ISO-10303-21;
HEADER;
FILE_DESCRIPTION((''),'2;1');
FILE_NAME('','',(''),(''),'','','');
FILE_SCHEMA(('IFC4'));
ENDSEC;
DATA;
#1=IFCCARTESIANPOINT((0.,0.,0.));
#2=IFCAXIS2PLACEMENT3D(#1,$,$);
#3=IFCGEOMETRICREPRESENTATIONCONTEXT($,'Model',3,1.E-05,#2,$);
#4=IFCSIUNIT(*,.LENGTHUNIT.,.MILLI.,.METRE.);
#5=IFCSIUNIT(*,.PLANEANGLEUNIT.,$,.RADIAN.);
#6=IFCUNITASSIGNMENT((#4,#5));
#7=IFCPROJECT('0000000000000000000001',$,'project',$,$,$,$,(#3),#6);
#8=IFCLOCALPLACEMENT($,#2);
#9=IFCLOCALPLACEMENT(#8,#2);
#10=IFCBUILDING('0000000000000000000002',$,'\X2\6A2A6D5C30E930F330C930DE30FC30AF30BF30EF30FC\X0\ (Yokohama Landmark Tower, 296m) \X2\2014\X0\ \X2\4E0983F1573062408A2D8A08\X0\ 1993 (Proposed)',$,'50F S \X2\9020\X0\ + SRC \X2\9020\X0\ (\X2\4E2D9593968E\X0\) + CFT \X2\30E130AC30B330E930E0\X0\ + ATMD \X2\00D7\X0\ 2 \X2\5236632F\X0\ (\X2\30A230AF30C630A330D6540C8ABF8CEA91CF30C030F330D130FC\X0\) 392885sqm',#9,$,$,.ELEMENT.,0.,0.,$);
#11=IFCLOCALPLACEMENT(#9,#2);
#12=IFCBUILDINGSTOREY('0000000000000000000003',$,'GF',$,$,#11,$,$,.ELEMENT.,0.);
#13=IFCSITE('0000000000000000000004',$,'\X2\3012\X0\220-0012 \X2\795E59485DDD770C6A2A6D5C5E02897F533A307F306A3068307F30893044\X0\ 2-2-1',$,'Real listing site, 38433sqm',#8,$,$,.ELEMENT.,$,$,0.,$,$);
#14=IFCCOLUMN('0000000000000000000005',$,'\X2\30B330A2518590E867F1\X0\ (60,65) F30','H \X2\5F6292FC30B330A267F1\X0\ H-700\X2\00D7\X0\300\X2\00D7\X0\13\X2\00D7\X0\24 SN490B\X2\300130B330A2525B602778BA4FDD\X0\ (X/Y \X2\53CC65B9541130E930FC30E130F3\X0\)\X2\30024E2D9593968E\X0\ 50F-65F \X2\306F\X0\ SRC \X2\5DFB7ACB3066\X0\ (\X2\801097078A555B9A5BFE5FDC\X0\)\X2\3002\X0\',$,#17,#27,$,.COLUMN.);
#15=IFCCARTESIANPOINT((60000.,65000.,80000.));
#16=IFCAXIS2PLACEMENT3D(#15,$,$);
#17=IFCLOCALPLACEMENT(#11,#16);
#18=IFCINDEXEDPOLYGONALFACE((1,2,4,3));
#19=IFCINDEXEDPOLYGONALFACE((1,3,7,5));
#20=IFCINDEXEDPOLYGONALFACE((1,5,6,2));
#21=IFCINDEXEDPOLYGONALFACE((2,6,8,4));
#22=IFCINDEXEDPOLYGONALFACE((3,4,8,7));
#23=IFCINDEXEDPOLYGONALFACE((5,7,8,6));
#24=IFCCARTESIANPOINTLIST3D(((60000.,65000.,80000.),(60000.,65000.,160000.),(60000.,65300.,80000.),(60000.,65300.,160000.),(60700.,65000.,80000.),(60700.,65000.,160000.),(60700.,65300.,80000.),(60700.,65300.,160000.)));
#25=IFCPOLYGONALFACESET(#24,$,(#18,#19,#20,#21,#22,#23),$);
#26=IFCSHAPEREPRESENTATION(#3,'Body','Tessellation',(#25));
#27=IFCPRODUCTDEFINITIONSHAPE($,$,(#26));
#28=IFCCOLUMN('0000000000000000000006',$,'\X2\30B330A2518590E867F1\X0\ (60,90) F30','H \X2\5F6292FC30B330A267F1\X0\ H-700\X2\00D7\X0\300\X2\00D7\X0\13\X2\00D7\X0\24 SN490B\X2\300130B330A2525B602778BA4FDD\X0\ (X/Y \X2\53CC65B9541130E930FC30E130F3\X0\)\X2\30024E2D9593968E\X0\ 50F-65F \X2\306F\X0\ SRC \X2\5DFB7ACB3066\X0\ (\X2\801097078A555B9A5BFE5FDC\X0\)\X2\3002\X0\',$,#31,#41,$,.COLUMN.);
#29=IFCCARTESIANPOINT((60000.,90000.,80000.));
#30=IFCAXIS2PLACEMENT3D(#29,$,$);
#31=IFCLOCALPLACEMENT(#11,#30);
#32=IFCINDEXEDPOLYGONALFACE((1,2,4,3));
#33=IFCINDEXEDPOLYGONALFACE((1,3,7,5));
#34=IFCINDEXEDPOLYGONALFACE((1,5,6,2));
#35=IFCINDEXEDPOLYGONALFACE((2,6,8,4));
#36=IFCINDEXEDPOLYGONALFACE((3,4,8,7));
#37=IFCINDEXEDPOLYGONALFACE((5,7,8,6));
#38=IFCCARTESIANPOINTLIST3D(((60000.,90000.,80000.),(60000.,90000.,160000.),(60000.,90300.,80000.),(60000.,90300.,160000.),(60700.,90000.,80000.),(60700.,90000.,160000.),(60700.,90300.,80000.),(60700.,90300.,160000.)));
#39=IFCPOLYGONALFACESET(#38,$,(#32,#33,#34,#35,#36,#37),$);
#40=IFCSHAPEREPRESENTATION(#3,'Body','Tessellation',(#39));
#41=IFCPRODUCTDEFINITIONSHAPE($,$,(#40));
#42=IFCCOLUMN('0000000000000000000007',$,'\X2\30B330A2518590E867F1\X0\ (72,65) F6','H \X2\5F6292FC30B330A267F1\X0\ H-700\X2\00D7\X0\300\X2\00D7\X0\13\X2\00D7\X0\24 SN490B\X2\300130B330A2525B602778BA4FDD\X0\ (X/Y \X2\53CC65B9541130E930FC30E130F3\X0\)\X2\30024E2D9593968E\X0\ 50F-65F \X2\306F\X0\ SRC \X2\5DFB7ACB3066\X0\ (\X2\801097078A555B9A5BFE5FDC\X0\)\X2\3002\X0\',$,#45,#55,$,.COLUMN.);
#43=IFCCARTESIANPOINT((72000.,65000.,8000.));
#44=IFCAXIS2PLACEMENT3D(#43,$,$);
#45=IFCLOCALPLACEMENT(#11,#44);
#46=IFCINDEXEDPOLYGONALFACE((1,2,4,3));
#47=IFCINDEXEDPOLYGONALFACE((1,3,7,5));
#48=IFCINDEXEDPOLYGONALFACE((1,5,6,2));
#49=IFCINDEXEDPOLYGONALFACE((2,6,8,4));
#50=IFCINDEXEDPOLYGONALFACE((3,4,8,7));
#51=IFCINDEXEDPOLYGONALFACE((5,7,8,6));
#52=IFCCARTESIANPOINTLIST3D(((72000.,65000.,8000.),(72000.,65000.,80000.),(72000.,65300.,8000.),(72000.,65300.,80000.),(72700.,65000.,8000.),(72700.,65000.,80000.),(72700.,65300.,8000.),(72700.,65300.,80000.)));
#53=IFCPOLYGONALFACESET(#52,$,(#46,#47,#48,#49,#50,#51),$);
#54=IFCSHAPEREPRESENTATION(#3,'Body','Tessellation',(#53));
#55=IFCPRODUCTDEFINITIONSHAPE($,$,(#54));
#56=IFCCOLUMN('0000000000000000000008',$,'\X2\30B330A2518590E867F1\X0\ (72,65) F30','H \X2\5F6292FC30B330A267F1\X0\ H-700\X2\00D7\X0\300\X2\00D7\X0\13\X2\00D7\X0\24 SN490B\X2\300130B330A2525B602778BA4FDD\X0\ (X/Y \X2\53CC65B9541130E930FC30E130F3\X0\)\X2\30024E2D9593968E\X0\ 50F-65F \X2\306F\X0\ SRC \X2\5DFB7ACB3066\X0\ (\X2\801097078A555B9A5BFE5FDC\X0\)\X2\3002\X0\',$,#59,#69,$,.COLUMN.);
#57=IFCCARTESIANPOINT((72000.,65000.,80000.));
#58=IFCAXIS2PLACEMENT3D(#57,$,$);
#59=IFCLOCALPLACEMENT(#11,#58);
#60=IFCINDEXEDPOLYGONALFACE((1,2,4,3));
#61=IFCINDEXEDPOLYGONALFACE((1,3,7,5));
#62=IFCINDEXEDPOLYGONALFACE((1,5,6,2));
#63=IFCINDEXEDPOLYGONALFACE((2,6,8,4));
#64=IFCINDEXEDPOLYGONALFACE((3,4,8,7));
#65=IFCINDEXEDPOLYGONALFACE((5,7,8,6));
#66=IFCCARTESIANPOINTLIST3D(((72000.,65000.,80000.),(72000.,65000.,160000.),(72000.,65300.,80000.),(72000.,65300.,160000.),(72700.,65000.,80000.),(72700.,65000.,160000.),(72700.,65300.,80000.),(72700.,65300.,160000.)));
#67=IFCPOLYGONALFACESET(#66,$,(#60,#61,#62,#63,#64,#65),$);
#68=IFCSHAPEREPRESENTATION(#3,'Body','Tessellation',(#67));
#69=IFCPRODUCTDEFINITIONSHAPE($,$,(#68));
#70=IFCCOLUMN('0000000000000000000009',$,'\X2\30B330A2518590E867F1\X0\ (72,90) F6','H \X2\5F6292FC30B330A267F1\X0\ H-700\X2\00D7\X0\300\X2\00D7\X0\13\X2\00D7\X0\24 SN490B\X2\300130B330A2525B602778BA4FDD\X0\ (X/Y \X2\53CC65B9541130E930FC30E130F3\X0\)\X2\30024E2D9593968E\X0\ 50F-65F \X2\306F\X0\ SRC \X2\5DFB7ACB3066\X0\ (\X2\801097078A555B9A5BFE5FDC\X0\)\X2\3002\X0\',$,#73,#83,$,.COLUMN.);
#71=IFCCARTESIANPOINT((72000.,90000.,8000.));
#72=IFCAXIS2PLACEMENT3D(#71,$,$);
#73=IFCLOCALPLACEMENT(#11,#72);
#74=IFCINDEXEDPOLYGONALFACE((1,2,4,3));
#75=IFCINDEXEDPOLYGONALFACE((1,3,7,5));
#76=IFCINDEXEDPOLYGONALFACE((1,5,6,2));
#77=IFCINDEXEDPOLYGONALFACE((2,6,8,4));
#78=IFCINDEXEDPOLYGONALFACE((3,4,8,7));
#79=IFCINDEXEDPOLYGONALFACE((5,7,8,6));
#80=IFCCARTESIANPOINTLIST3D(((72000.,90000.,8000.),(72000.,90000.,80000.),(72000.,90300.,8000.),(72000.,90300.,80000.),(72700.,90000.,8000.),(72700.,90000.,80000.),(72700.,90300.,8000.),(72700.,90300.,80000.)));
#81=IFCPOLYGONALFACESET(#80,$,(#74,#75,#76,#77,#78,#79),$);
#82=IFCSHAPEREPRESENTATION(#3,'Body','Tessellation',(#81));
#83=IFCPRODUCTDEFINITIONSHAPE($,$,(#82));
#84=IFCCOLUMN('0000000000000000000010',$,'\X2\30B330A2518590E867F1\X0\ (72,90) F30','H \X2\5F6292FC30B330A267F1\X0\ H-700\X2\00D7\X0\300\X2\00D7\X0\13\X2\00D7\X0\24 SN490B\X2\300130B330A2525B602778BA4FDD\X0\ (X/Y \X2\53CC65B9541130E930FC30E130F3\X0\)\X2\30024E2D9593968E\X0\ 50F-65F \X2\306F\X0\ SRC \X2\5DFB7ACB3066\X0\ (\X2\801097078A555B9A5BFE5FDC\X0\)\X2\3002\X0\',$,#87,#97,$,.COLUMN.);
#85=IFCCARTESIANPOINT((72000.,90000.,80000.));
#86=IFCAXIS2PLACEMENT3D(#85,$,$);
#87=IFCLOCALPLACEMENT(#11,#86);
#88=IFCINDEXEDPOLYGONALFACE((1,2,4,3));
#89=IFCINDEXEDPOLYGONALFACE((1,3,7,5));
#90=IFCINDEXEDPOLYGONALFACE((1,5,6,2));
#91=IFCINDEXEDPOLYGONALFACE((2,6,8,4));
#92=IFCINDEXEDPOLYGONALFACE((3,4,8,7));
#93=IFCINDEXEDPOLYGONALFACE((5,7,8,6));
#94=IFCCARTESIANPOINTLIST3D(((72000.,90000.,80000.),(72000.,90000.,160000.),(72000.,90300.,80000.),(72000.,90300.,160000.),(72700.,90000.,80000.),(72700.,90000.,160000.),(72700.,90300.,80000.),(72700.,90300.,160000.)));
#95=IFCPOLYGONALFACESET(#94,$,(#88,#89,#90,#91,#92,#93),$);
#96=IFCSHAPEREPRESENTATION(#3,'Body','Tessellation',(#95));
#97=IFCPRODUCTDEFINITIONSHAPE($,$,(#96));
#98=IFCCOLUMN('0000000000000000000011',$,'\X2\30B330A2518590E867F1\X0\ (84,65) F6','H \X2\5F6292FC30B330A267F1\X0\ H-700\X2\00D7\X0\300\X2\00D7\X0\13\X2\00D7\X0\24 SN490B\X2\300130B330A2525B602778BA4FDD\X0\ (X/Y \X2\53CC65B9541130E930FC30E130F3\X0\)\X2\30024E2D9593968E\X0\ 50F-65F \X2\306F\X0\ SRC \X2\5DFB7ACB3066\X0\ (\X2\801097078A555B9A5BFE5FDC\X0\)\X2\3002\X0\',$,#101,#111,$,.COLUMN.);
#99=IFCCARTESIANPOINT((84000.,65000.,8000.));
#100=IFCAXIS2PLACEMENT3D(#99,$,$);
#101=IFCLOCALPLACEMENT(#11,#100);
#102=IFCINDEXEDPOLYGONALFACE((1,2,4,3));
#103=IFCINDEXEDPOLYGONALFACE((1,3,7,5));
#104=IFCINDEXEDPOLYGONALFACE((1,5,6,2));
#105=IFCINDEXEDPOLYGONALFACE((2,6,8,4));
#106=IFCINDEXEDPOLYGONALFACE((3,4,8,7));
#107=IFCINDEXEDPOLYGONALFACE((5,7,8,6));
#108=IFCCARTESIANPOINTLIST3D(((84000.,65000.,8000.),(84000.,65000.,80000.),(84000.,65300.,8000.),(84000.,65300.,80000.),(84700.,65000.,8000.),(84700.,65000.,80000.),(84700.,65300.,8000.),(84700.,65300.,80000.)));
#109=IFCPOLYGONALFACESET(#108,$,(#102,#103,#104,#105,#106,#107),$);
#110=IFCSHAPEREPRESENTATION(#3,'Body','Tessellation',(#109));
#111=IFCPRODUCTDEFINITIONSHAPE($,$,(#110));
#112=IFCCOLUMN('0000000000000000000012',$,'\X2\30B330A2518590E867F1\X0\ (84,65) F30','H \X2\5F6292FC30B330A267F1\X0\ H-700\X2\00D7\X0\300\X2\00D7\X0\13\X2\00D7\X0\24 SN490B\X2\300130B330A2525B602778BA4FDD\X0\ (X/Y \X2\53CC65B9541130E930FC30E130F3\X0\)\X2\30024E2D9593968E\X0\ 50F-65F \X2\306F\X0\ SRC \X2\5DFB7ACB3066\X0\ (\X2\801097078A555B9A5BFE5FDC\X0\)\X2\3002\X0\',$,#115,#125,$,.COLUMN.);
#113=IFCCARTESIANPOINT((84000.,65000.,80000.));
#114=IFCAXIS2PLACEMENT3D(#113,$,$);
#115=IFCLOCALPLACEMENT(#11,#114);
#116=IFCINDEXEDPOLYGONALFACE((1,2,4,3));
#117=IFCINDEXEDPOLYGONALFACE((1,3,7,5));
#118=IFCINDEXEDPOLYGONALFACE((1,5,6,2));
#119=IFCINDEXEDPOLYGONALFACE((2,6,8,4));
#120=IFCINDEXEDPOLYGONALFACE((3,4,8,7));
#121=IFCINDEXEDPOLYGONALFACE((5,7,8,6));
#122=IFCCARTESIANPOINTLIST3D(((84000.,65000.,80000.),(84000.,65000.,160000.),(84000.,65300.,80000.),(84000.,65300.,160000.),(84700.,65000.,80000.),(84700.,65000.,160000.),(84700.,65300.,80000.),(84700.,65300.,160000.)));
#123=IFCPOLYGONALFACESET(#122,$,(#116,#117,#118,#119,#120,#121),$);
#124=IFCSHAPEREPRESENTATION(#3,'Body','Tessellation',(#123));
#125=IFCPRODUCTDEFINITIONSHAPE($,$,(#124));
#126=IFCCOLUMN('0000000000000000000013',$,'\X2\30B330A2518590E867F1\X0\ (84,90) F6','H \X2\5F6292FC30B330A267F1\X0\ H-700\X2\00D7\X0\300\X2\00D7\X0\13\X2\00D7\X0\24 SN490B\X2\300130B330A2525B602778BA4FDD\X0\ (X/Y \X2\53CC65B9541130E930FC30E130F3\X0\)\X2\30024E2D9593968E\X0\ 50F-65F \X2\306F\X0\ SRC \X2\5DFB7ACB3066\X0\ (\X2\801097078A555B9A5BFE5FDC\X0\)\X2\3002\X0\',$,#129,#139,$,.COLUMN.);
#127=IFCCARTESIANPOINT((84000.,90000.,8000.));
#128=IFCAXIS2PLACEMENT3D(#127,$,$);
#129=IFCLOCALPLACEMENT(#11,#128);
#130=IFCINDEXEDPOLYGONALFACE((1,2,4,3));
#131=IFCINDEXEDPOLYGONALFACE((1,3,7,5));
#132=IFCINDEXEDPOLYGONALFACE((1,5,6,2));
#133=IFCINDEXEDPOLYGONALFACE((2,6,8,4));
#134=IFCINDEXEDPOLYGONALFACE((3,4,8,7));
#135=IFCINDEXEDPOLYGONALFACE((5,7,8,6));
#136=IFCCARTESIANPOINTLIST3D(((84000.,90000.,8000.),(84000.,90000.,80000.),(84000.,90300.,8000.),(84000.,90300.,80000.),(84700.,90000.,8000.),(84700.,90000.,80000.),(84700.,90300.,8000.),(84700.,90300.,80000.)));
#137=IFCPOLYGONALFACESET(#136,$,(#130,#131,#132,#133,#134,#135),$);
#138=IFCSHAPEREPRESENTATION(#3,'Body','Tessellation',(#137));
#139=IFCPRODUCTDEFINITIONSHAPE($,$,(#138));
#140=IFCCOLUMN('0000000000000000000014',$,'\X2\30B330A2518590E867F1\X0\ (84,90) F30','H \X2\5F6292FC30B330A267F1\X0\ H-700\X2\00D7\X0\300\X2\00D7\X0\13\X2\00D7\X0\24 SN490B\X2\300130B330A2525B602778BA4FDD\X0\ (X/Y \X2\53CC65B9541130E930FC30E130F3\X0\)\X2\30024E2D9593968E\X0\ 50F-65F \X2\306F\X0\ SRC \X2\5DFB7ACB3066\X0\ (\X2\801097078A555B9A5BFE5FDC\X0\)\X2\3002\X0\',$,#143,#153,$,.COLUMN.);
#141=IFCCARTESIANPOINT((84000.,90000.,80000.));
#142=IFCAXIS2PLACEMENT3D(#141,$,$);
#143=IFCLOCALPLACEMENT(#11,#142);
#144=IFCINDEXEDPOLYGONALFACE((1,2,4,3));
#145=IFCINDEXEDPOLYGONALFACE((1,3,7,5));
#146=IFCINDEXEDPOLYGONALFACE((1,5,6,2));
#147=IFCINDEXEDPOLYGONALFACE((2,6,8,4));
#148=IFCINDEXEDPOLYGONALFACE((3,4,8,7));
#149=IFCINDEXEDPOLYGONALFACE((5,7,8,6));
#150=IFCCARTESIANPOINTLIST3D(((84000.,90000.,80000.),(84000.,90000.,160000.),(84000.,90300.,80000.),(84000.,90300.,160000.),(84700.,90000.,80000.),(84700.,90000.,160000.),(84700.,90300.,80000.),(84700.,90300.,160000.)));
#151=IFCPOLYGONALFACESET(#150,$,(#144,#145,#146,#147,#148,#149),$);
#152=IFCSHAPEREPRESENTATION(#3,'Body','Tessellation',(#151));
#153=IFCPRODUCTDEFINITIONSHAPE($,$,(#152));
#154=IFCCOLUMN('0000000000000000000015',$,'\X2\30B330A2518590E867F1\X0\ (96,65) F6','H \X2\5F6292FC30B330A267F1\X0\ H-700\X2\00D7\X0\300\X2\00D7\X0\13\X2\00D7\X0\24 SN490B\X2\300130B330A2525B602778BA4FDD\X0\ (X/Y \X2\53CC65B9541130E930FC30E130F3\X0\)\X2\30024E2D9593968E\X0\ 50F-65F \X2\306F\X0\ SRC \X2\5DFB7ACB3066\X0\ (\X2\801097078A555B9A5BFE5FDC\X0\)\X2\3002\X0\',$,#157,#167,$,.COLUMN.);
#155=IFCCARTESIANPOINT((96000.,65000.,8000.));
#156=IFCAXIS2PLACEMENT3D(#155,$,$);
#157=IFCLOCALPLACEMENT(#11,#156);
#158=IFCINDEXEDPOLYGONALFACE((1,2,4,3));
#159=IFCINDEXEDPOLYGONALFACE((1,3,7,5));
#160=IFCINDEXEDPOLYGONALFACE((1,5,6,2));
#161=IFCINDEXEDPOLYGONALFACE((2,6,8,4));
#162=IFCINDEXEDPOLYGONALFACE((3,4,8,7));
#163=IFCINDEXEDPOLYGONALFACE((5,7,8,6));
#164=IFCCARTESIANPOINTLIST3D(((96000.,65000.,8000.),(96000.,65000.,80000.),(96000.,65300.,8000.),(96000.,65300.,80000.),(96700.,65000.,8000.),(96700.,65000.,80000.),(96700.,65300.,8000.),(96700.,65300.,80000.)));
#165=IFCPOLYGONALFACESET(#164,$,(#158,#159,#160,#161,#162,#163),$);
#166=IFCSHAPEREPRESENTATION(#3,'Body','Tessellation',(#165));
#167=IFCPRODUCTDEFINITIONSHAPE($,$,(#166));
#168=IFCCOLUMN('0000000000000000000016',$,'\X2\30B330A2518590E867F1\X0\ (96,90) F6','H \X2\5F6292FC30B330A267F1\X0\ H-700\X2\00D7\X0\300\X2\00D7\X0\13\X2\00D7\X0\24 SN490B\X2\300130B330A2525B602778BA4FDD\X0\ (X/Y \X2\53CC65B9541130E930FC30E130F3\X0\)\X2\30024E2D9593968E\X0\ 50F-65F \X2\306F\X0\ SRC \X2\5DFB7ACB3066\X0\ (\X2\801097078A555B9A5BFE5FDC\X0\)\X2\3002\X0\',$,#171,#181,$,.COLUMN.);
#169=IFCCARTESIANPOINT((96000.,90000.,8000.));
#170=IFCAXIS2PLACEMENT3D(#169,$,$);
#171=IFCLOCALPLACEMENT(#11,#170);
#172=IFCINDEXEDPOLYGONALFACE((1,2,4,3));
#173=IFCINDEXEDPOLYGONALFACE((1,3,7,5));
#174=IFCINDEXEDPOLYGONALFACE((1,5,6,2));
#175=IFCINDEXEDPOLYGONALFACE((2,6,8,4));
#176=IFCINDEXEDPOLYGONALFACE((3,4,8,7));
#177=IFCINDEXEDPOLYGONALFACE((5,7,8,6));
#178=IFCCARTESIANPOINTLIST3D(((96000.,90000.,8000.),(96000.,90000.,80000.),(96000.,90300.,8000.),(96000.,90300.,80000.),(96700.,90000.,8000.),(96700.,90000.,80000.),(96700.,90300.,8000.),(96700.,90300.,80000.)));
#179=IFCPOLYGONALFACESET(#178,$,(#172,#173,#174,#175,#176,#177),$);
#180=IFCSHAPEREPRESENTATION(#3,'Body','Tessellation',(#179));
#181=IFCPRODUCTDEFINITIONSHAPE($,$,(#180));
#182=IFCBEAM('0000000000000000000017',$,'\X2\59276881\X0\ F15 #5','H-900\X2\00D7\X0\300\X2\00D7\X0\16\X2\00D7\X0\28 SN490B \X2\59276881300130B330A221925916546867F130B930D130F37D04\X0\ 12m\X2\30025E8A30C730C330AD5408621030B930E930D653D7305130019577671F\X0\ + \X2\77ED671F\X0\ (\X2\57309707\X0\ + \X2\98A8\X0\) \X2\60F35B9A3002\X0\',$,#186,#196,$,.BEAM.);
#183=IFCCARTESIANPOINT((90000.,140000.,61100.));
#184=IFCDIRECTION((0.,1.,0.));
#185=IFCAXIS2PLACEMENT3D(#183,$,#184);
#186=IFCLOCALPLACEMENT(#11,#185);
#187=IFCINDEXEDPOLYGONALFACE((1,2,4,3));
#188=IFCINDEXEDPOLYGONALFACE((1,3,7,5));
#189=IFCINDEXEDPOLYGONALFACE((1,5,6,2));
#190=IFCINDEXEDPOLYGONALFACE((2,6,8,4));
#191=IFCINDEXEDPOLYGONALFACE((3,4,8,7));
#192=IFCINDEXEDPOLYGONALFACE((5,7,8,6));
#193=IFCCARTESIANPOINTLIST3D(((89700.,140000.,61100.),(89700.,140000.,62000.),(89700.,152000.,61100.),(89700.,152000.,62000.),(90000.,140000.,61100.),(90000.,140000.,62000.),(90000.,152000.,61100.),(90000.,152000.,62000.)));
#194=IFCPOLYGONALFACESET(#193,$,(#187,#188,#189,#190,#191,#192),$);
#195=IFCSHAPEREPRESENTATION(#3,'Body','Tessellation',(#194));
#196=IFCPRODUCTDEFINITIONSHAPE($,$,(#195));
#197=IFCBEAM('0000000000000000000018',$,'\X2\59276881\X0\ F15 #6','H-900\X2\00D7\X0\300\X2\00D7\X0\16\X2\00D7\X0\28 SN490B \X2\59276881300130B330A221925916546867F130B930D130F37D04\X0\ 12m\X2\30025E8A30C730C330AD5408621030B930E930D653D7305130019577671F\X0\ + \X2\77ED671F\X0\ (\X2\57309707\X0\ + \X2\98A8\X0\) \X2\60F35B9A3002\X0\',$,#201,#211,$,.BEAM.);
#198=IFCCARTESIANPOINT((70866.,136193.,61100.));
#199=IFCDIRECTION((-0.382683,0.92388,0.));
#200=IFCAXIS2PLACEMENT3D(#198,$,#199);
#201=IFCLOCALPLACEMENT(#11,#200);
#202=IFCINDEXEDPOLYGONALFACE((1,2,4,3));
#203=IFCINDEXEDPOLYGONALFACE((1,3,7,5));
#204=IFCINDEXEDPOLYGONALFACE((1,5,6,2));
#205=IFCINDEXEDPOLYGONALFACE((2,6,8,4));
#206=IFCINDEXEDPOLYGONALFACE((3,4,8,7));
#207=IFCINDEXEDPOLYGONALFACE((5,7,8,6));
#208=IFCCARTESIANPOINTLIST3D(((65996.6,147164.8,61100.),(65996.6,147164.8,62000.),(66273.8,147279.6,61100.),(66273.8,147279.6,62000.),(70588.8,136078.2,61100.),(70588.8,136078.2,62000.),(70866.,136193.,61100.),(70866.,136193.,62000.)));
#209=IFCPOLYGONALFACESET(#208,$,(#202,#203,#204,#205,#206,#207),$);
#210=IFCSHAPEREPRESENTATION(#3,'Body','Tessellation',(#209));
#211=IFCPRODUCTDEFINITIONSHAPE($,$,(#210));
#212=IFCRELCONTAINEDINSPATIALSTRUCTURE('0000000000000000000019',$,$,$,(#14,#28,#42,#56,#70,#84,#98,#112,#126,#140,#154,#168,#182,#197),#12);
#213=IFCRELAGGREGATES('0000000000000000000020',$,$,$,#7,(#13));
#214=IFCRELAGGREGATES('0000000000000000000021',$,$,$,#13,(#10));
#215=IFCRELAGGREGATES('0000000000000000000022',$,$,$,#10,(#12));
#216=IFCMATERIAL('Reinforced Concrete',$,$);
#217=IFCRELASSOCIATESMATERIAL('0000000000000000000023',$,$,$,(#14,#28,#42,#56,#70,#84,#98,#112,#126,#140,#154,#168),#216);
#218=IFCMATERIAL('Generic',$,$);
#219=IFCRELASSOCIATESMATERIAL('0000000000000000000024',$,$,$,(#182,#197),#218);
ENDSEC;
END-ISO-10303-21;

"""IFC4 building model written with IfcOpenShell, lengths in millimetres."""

from ifc_helpers import new_model, si_unit, frame, frame_2d, origin, place, context, project, spatial, rectangle, extrude, material, element, save


model = new_model("IFC4")

# Units and contexts
model_context = context("Model", 3, precision=1e-05, world=origin())
ifc_project = project(units=[si_unit("LENGTHUNIT", "METRE", prefix="MILLI"), si_unit("PLANEANGLEUNIT", "RADIAN")], contexts=[model_context])

# Site, building, storey
site_placement = place(None, origin())
site = spatial("IfcSite", under=ifc_project, at=site_placement, Name="〒220-0012 神奈川県横浜市西区みなとみらい 2-2-1", ObjectType="Real listing site, 38433sqm", CompositionType="ELEMENT", RefElevation=0.0)
building_placement = place(site_placement, origin())
building = spatial("IfcBuilding", under=site, at=building_placement, Name="横浜ランドマークタワー (Yokohama Landmark Tower, 296m) — 三菱地所設計 1993 (Proposed)", ObjectType="50F S 造 + SRC 造 (中間階) + CFT メガコラム + ATMD × 2 制振 (アクティブ同調質量ダンパー) 392885sqm", CompositionType="ELEMENT", ElevationOfRefHeight=0.0, ElevationOfTerrain=0.0)
storey_placement = place(building_placement, origin())
storey = spatial("IfcBuildingStorey", under=building, at=storey_placement, Name="GF", CompositionType="ELEMENT", Elevation=0.0)

# Columns
ifc_material_1 = material(Name="Reinforced Concrete")
column_1_placement = place(storey_placement, frame((60000.0, 65000.0, 80000.0)))
element("IfcColumn", 1, at=column_1_placement, inside=storey, material=ifc_material_1, Name="コア内部柱 (60,65) F30", Description="H 形鋼コア柱 H-700×300×13×24 SN490B、コア剛性確保 (X/Y 双方向ラーメン)。中間階 50F-65F は SRC 巻立て (耐震評定対応)。", PredefinedType="COLUMN", context=model_context, shape_type="SweptSolid", body=[
    extrude(rectangle(XDim=700.0, YDim=300.0, at=frame_2d((350.0, 150.0))), frame((60000.0, 65000.0, 80000.0)), (0.0, 0.0, 1.0), 80000.0),
])
column_2_placement = place(storey_placement, frame((60000.0, 90000.0, 80000.0)))
element("IfcColumn", 2, at=column_2_placement, inside=storey, material=ifc_material_1, Name="コア内部柱 (60,90) F30", Description="H 形鋼コア柱 H-700×300×13×24 SN490B、コア剛性確保 (X/Y 双方向ラーメン)。中間階 50F-65F は SRC 巻立て (耐震評定対応)。", PredefinedType="COLUMN", context=model_context, shape_type="SweptSolid", body=[
    extrude(rectangle(XDim=700.0, YDim=300.0, at=frame_2d((350.0, 150.0))), frame((60000.0, 90000.0, 80000.0)), (0.0, 0.0, 1.0), 80000.0),
])
column_3_placement = place(storey_placement, frame((72000.0, 65000.0, 8000.0)))
element("IfcColumn", 3, at=column_3_placement, inside=storey, material=ifc_material_1, Name="コア内部柱 (72,65) F6", Description="H 形鋼コア柱 H-700×300×13×24 SN490B、コア剛性確保 (X/Y 双方向ラーメン)。中間階 50F-65F は SRC 巻立て (耐震評定対応)。", PredefinedType="COLUMN", context=model_context, shape_type="SweptSolid", body=[
    extrude(rectangle(XDim=700.0, YDim=300.0, at=frame_2d((350.0, 150.0))), frame((72000.0, 65000.0, 8000.0)), (0.0, 0.0, 1.0), 72000.0),
])
column_4_placement = place(storey_placement, frame((72000.0, 65000.0, 80000.0)))
element("IfcColumn", 4, at=column_4_placement, inside=storey, material=ifc_material_1, Name="コア内部柱 (72,65) F30", Description="H 形鋼コア柱 H-700×300×13×24 SN490B、コア剛性確保 (X/Y 双方向ラーメン)。中間階 50F-65F は SRC 巻立て (耐震評定対応)。", PredefinedType="COLUMN", context=model_context, shape_type="SweptSolid", body=[
    extrude(rectangle(XDim=700.0, YDim=300.0, at=frame_2d((350.0, 150.0))), frame((72000.0, 65000.0, 80000.0)), (0.0, 0.0, 1.0), 80000.0),
])
column_5_placement = place(storey_placement, frame((72000.0, 90000.0, 8000.0)))
element("IfcColumn", 5, at=column_5_placement, inside=storey, material=ifc_material_1, Name="コア内部柱 (72,90) F6", Description="H 形鋼コア柱 H-700×300×13×24 SN490B、コア剛性確保 (X/Y 双方向ラーメン)。中間階 50F-65F は SRC 巻立て (耐震評定対応)。", PredefinedType="COLUMN", context=model_context, shape_type="SweptSolid", body=[
    extrude(rectangle(XDim=700.0, YDim=300.0, at=frame_2d((350.0, 150.0))), frame((72000.0, 90000.0, 8000.0)), (0.0, 0.0, 1.0), 72000.0),
])
column_6_placement = place(storey_placement, frame((72000.0, 90000.0, 80000.0)))
element("IfcColumn", 6, at=column_6_placement, inside=storey, material=ifc_material_1, Name="コア内部柱 (72,90) F30", Description="H 形鋼コア柱 H-700×300×13×24 SN490B、コア剛性確保 (X/Y 双方向ラーメン)。中間階 50F-65F は SRC 巻立て (耐震評定対応)。", PredefinedType="COLUMN", context=model_context, shape_type="SweptSolid", body=[
    extrude(rectangle(XDim=700.0, YDim=300.0, at=frame_2d((350.0, 150.0))), frame((72000.0, 90000.0, 80000.0)), (0.0, 0.0, 1.0), 80000.0),
])
column_7_placement = place(storey_placement, frame((84000.0, 65000.0, 8000.0)))
element("IfcColumn", 7, at=column_7_placement, inside=storey, material=ifc_material_1, Name="コア内部柱 (84,65) F6", Description="H 形鋼コア柱 H-700×300×13×24 SN490B、コア剛性確保 (X/Y 双方向ラーメン)。中間階 50F-65F は SRC 巻立て (耐震評定対応)。", PredefinedType="COLUMN", context=model_context, shape_type="SweptSolid", body=[
    extrude(rectangle(XDim=700.0, YDim=300.0, at=frame_2d((350.0, 150.0))), frame((84000.0, 65000.0, 8000.0)), (0.0, 0.0, 1.0), 72000.0),
])
column_8_placement = place(storey_placement, frame((84000.0, 65000.0, 80000.0)))
element("IfcColumn", 8, at=column_8_placement, inside=storey, material=ifc_material_1, Name="コア内部柱 (84,65) F30", Description="H 形鋼コア柱 H-700×300×13×24 SN490B、コア剛性確保 (X/Y 双方向ラーメン)。中間階 50F-65F は SRC 巻立て (耐震評定対応)。", PredefinedType="COLUMN", context=model_context, shape_type="SweptSolid", body=[
    extrude(rectangle(XDim=700.0, YDim=300.0, at=frame_2d((350.0, 150.0))), frame((84000.0, 65000.0, 80000.0)), (0.0, 0.0, 1.0), 80000.0),
])
column_9_placement = place(storey_placement, frame((84000.0, 90000.0, 8000.0)))
element("IfcColumn", 9, at=column_9_placement, inside=storey, material=ifc_material_1, Name="コア内部柱 (84,90) F6", Description="H 形鋼コア柱 H-700×300×13×24 SN490B、コア剛性確保 (X/Y 双方向ラーメン)。中間階 50F-65F は SRC 巻立て (耐震評定対応)。", PredefinedType="COLUMN", context=model_context, shape_type="SweptSolid", body=[
    extrude(rectangle(XDim=700.0, YDim=300.0, at=frame_2d((350.0, 150.0))), frame((84000.0, 90000.0, 8000.0)), (0.0, 0.0, 1.0), 72000.0),
])
column_10_placement = place(storey_placement, frame((84000.0, 90000.0, 80000.0)))
element("IfcColumn", 10, at=column_10_placement, inside=storey, material=ifc_material_1, Name="コア内部柱 (84,90) F30", Description="H 形鋼コア柱 H-700×300×13×24 SN490B、コア剛性確保 (X/Y 双方向ラーメン)。中間階 50F-65F は SRC 巻立て (耐震評定対応)。", PredefinedType="COLUMN", context=model_context, shape_type="SweptSolid", body=[
    extrude(rectangle(XDim=700.0, YDim=300.0, at=frame_2d((350.0, 150.0))), frame((84000.0, 90000.0, 80000.0)), (0.0, 0.0, 1.0), 80000.0),
])
column_11_placement = place(storey_placement, frame((96000.0, 65000.0, 8000.0)))
element("IfcColumn", 11, at=column_11_placement, inside=storey, material=ifc_material_1, Name="コア内部柱 (96,65) F6", Description="H 形鋼コア柱 H-700×300×13×24 SN490B、コア剛性確保 (X/Y 双方向ラーメン)。中間階 50F-65F は SRC 巻立て (耐震評定対応)。", PredefinedType="COLUMN", context=model_context, shape_type="SweptSolid", body=[
    extrude(rectangle(XDim=700.0, YDim=300.0, at=frame_2d((350.0, 150.0))), frame((96000.0, 65000.0, 8000.0)), (0.0, 0.0, 1.0), 72000.0),
])
column_12_placement = place(storey_placement, frame((96000.0, 90000.0, 8000.0)))
element("IfcColumn", 12, at=column_12_placement, inside=storey, material=ifc_material_1, Name="コア内部柱 (96,90) F6", Description="H 形鋼コア柱 H-700×300×13×24 SN490B、コア剛性確保 (X/Y 双方向ラーメン)。中間階 50F-65F は SRC 巻立て (耐震評定対応)。", PredefinedType="COLUMN", context=model_context, shape_type="SweptSolid", body=[
    extrude(rectangle(XDim=700.0, YDim=300.0, at=frame_2d((350.0, 150.0))), frame((96000.0, 90000.0, 8000.0)), (0.0, 0.0, 1.0), 72000.0),
])

# Beams
ifc_material_2 = material(Name="Generic")
beam_1_placement = place(storey_placement, frame((90000.0, 140000.0, 61100.0), x_axis=(0.0, 1.0, 0.0)))
element("IfcBeam", 13, at=beam_1_placement, inside=storey, material=ifc_material_2, Name="大梁 F15 #5", Description="H-900×300×16×28 SN490B 大梁、コア→外周柱スパン約 12m。床デッキ合成スラブ受け、長期 + 短期 (地震 + 風) 想定。", PredefinedType="BEAM", context=model_context, shape_type="SweptSolid", body=[
    extrude(rectangle(XDim=12000.0, YDim=300.0, at=frame_2d((6000.0, 150.0))), frame((90000.0, 140000.0, 61100.0), x_axis=(0.0, 1.0, 0.0)), (0.0, 0.0, 1.0), 900.0),
])
beam_2_placement = place(storey_placement, frame((70866.0, 136193.0, 61100.0), x_axis=(-0.382683, 0.92388, 0.0)))
element("IfcBeam", 14, at=beam_2_placement, inside=storey, material=ifc_material_2, Name="大梁 F15 #6", Description="H-900×300×16×28 SN490B 大梁、コア→外周柱スパン約 12m。床デッキ合成スラブ受け、長期 + 短期 (地震 + 風) 想定。", PredefinedType="BEAM", context=model_context, shape_type="SweptSolid", body=[
    extrude(rectangle(XDim=12000.0, YDim=300.0, at=frame_2d((6000.0, 150.0))), frame((70866.0, 136193.0, 61100.0), x_axis=(-0.382683, 0.92388, 0.0)), (0.0, 0.0, 1.0), 900.0),
])

save(model, "model.ifc")
